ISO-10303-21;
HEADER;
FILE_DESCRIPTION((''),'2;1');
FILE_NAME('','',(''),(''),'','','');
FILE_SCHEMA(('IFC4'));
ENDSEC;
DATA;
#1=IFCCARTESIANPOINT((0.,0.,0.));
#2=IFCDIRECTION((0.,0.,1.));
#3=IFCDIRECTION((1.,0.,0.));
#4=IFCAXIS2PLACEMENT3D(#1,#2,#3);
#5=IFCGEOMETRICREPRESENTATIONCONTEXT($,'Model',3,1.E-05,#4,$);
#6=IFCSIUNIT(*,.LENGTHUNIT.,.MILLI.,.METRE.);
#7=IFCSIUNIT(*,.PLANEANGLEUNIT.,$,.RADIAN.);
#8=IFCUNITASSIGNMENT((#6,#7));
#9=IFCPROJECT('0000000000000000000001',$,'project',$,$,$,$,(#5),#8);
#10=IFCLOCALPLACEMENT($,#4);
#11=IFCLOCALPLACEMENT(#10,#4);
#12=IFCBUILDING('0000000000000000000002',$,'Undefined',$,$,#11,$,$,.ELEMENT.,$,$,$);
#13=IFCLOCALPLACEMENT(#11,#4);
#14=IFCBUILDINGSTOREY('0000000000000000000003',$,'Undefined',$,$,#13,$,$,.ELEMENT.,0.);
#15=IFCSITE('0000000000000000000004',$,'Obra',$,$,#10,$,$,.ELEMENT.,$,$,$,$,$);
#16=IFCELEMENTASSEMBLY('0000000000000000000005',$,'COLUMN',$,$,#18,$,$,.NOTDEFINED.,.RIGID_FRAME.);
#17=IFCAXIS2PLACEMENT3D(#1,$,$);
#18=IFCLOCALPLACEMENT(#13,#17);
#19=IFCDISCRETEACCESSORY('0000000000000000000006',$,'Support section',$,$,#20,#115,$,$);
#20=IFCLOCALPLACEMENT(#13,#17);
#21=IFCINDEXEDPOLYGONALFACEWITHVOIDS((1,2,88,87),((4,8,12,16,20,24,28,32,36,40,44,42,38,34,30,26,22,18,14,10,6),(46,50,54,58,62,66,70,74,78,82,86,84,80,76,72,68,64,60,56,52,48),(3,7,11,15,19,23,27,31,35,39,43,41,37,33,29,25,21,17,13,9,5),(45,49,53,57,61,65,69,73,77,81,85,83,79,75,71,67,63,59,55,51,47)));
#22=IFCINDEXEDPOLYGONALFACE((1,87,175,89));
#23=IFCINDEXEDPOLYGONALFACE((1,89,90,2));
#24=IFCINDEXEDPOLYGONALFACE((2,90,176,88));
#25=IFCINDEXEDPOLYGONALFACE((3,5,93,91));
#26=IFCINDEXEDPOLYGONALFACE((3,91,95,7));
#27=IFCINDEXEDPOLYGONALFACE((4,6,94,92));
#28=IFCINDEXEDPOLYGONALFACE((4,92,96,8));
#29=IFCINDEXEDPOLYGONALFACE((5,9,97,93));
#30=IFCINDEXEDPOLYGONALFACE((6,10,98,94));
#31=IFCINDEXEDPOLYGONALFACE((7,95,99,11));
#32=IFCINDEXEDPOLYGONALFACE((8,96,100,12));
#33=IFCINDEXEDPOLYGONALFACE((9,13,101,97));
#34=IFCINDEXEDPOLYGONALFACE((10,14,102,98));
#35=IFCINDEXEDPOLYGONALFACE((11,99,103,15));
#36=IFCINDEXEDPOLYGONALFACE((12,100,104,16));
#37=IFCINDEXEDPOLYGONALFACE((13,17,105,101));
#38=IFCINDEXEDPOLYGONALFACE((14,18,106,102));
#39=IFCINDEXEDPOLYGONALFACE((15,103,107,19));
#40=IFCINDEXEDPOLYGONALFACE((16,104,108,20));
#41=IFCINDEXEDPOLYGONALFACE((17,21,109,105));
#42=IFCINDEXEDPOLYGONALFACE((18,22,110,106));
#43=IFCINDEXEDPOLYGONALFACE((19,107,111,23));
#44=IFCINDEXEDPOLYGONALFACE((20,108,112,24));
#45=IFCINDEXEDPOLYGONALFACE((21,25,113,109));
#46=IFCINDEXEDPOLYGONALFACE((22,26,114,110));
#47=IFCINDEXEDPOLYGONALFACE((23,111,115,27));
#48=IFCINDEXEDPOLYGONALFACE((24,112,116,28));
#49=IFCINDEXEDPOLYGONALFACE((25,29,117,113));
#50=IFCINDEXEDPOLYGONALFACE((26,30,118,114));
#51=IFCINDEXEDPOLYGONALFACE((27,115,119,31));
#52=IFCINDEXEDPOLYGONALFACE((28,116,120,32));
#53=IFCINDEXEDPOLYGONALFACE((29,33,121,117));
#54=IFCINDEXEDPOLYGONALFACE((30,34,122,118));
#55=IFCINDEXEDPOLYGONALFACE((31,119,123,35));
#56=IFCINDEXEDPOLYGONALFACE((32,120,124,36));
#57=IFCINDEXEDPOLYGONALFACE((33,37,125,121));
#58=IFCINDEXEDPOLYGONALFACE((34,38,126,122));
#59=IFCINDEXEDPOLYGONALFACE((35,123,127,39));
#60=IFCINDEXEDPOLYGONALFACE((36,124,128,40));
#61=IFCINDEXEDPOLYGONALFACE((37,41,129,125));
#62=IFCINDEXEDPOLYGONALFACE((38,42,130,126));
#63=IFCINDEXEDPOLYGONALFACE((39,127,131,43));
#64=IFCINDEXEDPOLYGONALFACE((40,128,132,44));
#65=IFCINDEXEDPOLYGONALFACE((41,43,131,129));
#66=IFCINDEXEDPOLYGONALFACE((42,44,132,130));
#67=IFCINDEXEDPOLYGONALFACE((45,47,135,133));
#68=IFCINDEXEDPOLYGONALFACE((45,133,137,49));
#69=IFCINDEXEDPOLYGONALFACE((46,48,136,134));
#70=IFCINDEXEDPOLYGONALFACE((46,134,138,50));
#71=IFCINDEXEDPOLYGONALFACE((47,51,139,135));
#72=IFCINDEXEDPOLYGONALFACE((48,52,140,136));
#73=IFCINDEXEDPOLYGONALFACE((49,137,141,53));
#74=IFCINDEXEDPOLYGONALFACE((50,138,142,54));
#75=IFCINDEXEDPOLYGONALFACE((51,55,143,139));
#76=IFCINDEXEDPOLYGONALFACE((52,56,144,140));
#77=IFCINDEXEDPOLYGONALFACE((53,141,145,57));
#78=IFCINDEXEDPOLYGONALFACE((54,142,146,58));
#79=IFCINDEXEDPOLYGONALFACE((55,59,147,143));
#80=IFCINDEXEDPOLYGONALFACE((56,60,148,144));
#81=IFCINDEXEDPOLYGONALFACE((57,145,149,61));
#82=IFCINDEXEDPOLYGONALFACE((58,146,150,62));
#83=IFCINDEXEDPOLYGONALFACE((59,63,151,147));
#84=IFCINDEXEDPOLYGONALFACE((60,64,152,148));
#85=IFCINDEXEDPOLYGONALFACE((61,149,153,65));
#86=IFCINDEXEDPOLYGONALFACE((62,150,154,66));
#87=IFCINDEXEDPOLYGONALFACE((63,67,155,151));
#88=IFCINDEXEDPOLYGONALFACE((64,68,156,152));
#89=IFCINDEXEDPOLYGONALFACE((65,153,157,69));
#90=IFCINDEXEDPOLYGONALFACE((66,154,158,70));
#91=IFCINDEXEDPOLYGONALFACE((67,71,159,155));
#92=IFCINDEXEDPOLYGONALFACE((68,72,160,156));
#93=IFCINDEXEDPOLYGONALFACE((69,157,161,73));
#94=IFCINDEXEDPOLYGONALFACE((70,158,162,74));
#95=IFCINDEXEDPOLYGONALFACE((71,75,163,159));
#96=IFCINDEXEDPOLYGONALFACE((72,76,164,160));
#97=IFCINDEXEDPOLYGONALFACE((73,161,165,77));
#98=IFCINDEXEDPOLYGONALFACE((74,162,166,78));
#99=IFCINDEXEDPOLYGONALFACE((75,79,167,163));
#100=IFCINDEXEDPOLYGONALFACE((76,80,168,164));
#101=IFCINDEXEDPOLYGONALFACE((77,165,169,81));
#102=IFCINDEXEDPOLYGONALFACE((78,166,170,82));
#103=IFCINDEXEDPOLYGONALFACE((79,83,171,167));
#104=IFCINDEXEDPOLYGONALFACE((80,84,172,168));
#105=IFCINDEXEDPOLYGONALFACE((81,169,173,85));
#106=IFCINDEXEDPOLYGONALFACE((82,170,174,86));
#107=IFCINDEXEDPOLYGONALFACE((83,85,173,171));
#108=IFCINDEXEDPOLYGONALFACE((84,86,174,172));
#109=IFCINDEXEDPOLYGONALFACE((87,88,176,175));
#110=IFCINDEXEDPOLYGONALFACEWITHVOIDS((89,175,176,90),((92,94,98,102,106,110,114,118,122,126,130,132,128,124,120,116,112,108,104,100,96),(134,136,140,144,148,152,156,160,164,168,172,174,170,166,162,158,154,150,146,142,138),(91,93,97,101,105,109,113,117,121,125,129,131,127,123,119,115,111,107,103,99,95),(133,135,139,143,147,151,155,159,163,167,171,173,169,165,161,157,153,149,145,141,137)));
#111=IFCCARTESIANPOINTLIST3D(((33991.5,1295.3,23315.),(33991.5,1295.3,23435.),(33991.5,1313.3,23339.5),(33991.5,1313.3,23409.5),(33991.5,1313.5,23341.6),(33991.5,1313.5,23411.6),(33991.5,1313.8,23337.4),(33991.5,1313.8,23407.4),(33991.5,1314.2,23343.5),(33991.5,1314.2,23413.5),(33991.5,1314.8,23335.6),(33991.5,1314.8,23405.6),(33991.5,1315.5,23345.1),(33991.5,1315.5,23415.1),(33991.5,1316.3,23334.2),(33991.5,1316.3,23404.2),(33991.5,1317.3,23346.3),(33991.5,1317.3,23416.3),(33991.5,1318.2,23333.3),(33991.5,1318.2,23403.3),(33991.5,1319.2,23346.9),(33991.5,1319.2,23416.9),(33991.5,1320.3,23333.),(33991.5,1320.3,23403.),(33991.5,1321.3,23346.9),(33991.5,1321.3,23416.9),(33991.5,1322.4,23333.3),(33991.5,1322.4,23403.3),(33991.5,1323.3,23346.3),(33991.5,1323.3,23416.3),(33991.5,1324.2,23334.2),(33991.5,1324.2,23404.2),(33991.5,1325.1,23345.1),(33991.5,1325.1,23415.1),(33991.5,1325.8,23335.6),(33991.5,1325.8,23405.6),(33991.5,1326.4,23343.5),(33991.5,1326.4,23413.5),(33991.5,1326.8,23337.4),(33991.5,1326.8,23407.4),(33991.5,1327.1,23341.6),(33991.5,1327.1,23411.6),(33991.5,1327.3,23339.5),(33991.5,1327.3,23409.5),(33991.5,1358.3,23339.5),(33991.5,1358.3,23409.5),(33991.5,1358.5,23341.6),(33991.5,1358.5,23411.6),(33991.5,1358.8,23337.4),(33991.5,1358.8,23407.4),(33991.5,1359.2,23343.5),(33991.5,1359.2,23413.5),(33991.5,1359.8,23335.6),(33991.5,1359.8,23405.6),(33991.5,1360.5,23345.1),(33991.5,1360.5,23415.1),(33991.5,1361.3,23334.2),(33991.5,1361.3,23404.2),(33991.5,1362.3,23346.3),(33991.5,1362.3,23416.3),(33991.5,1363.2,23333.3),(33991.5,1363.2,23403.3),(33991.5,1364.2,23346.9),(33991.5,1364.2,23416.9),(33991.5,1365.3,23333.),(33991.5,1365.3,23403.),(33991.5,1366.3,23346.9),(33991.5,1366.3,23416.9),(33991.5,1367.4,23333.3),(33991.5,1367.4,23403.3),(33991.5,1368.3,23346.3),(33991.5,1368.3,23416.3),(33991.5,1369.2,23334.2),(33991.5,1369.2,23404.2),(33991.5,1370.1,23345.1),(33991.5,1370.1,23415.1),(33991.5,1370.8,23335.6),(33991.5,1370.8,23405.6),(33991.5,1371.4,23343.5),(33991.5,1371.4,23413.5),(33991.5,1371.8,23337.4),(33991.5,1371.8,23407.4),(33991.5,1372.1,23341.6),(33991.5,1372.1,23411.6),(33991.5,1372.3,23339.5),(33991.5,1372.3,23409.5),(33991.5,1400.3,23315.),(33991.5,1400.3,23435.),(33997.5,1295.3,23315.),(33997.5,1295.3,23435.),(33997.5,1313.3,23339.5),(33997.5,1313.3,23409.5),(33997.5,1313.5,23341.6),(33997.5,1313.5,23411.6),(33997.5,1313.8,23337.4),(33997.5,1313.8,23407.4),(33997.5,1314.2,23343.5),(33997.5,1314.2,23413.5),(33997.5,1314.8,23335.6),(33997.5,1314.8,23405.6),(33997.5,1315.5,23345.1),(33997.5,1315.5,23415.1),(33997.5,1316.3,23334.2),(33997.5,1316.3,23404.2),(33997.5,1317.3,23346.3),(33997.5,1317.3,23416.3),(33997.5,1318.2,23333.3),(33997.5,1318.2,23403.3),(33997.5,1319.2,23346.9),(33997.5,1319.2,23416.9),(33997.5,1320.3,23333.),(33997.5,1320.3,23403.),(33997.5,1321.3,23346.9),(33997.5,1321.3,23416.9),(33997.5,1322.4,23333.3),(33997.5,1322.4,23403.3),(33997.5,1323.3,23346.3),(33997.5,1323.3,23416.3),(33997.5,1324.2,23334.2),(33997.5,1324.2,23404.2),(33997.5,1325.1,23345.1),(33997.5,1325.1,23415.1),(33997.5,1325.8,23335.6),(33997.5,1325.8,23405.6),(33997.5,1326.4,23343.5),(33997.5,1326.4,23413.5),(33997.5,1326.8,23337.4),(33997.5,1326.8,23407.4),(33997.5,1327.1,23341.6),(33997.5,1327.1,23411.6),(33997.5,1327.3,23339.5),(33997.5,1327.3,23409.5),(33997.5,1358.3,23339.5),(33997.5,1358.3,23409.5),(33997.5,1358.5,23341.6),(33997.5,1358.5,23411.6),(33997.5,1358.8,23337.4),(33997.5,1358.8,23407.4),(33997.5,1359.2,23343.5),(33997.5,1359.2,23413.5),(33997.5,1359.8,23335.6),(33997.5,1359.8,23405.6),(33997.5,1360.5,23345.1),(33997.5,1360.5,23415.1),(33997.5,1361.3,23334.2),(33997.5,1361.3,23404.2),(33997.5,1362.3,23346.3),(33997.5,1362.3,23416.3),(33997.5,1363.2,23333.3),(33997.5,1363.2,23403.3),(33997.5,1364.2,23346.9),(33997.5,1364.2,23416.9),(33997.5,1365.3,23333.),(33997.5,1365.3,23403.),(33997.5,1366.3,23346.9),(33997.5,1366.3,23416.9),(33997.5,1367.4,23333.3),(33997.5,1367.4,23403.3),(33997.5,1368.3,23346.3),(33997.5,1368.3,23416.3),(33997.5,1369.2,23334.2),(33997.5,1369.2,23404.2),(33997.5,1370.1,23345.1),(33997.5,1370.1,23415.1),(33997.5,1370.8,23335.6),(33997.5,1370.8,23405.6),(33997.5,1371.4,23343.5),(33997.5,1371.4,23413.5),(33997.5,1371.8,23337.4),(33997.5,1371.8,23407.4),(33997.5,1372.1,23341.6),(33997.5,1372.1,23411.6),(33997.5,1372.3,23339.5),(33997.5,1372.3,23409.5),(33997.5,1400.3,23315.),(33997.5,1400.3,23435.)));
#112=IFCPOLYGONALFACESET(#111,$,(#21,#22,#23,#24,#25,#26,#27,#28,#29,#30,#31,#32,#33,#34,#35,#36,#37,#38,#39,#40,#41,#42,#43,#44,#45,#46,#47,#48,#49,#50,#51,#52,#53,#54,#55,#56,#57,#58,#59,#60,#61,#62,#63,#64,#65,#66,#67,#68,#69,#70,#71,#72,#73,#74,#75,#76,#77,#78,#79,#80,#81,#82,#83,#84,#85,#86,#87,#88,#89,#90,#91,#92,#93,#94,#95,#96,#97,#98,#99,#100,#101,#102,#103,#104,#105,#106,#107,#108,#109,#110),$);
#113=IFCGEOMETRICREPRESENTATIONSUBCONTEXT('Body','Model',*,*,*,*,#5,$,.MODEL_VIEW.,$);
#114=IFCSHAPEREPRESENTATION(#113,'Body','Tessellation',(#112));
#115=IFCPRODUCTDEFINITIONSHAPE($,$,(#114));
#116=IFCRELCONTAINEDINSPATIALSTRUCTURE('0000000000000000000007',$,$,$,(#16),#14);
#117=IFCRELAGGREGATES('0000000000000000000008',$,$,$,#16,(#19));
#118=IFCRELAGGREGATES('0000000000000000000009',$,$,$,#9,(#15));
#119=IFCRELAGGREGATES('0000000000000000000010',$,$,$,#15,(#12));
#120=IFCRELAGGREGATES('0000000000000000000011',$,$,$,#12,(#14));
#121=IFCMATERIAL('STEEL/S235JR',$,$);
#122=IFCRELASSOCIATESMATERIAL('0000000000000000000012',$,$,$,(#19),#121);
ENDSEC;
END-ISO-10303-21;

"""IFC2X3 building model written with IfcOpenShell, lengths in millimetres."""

from ifc_helpers import new_model, si_unit, frame, origin_with_axes, origin_2d_with_axis, place, context, subcontext, project, spatial, rectangle, circle, extrude, source, transform, mapped, material, element, aggregate, save


model = new_model("IFC2X3")

# Units and contexts
model_context = context("Model", 3, precision=1e-05, world=origin_with_axes())
body_context = subcontext(model_context, "Body", "Model", "MODEL_VIEW")
ifc_project = project(units=[si_unit("LENGTHUNIT", "METRE", prefix="MILLI"), si_unit("PLANEANGLEUNIT", "RADIAN")], contexts=[model_context])

# Site, building, storey
site_placement = place(None, origin_with_axes())
site = spatial("IfcSite", under=ifc_project, at=site_placement, Name="Obra", CompositionType="ELEMENT")
building_placement = place(site_placement, origin_with_axes())
building = spatial("IfcBuilding", under=site, at=building_placement, Name="Undefined", CompositionType="ELEMENT")
storey_placement = place(building_placement, origin_with_axes())
storey = spatial("IfcBuildingStorey", under=building, at=storey_placement, Name="Undefined", CompositionType="ELEMENT", Elevation=0.0)

# Element assembly, discrete accessory, opening
assembly_1_placement = place(storey_placement, origin_with_axes())
assembly_1 = element("IfcElementAssembly", 1, at=assembly_1_placement, inside=storey, Name="COLUMN", AssemblyPlace="NOTDEFINED", PredefinedType="RIGID_FRAME")
ifc_material_1 = material(Name="STEEL/S235JR")
discrete_accessory_1_placement = place(assembly_1_placement, frame((33994.5, 1347.8, 23315.0), z_axis=(0.0, 0.0, 1.0), x_axis=(0.0, 1.0, 0.0)))
discrete_accessory_1 = element("IfcDiscreteAccessory", 2, at=discrete_accessory_1_placement, material=ifc_material_1, Name="Support section", context=body_context, shape_type="SweptSolid", body=[
    extrude(rectangle(XDim=6.0, YDim=105.0, at=origin_2d_with_axis()), frame((0.0, 0.0, 120.0), z_axis=(0.0, 0.0, -1.0), x_axis=(0.0, 1.0, 0.0)), (0.0, 0.0, 1.0), 120.0),
])
shared_shape_1 = source(origin_with_axes(), body_context, "Body", "SweptSolid", [
    extrude(circle(Radius=7.0, at=origin_2d_with_axis()), frame((0.0, -8.6, 0.0), z_axis=(0.0, 1.0, 0.0), x_axis=(1.0, 0.0, 0.0)), (0.0, 0.0, 1.0), 6.2),
])
opening_1_placement = place(assembly_1_placement, frame((34000.0, 1390.3, 23455.0), z_axis=(0.0, -1.0, 0.0), x_axis=(0.0, 0.0, -1.0)))
element("IfcOpeningElement", 3, at=opening_1_placement, cuts=discrete_accessory_1, ObjectType="Opening", context=body_context, shape_type="MappedRepresentation", body=[
    mapped(shared_shape_1, transform((45.0, 0.0, 25.0))),
    mapped(shared_shape_1, transform((45.0, 0.0, 70.0))),
    mapped(shared_shape_1, transform((115.0, 0.0, 25.0))),
    mapped(shared_shape_1, transform((115.0, 0.0, 70.0))),
])
aggregate(assembly_1, [discrete_accessory_1])

save(model, "model.ifc")
